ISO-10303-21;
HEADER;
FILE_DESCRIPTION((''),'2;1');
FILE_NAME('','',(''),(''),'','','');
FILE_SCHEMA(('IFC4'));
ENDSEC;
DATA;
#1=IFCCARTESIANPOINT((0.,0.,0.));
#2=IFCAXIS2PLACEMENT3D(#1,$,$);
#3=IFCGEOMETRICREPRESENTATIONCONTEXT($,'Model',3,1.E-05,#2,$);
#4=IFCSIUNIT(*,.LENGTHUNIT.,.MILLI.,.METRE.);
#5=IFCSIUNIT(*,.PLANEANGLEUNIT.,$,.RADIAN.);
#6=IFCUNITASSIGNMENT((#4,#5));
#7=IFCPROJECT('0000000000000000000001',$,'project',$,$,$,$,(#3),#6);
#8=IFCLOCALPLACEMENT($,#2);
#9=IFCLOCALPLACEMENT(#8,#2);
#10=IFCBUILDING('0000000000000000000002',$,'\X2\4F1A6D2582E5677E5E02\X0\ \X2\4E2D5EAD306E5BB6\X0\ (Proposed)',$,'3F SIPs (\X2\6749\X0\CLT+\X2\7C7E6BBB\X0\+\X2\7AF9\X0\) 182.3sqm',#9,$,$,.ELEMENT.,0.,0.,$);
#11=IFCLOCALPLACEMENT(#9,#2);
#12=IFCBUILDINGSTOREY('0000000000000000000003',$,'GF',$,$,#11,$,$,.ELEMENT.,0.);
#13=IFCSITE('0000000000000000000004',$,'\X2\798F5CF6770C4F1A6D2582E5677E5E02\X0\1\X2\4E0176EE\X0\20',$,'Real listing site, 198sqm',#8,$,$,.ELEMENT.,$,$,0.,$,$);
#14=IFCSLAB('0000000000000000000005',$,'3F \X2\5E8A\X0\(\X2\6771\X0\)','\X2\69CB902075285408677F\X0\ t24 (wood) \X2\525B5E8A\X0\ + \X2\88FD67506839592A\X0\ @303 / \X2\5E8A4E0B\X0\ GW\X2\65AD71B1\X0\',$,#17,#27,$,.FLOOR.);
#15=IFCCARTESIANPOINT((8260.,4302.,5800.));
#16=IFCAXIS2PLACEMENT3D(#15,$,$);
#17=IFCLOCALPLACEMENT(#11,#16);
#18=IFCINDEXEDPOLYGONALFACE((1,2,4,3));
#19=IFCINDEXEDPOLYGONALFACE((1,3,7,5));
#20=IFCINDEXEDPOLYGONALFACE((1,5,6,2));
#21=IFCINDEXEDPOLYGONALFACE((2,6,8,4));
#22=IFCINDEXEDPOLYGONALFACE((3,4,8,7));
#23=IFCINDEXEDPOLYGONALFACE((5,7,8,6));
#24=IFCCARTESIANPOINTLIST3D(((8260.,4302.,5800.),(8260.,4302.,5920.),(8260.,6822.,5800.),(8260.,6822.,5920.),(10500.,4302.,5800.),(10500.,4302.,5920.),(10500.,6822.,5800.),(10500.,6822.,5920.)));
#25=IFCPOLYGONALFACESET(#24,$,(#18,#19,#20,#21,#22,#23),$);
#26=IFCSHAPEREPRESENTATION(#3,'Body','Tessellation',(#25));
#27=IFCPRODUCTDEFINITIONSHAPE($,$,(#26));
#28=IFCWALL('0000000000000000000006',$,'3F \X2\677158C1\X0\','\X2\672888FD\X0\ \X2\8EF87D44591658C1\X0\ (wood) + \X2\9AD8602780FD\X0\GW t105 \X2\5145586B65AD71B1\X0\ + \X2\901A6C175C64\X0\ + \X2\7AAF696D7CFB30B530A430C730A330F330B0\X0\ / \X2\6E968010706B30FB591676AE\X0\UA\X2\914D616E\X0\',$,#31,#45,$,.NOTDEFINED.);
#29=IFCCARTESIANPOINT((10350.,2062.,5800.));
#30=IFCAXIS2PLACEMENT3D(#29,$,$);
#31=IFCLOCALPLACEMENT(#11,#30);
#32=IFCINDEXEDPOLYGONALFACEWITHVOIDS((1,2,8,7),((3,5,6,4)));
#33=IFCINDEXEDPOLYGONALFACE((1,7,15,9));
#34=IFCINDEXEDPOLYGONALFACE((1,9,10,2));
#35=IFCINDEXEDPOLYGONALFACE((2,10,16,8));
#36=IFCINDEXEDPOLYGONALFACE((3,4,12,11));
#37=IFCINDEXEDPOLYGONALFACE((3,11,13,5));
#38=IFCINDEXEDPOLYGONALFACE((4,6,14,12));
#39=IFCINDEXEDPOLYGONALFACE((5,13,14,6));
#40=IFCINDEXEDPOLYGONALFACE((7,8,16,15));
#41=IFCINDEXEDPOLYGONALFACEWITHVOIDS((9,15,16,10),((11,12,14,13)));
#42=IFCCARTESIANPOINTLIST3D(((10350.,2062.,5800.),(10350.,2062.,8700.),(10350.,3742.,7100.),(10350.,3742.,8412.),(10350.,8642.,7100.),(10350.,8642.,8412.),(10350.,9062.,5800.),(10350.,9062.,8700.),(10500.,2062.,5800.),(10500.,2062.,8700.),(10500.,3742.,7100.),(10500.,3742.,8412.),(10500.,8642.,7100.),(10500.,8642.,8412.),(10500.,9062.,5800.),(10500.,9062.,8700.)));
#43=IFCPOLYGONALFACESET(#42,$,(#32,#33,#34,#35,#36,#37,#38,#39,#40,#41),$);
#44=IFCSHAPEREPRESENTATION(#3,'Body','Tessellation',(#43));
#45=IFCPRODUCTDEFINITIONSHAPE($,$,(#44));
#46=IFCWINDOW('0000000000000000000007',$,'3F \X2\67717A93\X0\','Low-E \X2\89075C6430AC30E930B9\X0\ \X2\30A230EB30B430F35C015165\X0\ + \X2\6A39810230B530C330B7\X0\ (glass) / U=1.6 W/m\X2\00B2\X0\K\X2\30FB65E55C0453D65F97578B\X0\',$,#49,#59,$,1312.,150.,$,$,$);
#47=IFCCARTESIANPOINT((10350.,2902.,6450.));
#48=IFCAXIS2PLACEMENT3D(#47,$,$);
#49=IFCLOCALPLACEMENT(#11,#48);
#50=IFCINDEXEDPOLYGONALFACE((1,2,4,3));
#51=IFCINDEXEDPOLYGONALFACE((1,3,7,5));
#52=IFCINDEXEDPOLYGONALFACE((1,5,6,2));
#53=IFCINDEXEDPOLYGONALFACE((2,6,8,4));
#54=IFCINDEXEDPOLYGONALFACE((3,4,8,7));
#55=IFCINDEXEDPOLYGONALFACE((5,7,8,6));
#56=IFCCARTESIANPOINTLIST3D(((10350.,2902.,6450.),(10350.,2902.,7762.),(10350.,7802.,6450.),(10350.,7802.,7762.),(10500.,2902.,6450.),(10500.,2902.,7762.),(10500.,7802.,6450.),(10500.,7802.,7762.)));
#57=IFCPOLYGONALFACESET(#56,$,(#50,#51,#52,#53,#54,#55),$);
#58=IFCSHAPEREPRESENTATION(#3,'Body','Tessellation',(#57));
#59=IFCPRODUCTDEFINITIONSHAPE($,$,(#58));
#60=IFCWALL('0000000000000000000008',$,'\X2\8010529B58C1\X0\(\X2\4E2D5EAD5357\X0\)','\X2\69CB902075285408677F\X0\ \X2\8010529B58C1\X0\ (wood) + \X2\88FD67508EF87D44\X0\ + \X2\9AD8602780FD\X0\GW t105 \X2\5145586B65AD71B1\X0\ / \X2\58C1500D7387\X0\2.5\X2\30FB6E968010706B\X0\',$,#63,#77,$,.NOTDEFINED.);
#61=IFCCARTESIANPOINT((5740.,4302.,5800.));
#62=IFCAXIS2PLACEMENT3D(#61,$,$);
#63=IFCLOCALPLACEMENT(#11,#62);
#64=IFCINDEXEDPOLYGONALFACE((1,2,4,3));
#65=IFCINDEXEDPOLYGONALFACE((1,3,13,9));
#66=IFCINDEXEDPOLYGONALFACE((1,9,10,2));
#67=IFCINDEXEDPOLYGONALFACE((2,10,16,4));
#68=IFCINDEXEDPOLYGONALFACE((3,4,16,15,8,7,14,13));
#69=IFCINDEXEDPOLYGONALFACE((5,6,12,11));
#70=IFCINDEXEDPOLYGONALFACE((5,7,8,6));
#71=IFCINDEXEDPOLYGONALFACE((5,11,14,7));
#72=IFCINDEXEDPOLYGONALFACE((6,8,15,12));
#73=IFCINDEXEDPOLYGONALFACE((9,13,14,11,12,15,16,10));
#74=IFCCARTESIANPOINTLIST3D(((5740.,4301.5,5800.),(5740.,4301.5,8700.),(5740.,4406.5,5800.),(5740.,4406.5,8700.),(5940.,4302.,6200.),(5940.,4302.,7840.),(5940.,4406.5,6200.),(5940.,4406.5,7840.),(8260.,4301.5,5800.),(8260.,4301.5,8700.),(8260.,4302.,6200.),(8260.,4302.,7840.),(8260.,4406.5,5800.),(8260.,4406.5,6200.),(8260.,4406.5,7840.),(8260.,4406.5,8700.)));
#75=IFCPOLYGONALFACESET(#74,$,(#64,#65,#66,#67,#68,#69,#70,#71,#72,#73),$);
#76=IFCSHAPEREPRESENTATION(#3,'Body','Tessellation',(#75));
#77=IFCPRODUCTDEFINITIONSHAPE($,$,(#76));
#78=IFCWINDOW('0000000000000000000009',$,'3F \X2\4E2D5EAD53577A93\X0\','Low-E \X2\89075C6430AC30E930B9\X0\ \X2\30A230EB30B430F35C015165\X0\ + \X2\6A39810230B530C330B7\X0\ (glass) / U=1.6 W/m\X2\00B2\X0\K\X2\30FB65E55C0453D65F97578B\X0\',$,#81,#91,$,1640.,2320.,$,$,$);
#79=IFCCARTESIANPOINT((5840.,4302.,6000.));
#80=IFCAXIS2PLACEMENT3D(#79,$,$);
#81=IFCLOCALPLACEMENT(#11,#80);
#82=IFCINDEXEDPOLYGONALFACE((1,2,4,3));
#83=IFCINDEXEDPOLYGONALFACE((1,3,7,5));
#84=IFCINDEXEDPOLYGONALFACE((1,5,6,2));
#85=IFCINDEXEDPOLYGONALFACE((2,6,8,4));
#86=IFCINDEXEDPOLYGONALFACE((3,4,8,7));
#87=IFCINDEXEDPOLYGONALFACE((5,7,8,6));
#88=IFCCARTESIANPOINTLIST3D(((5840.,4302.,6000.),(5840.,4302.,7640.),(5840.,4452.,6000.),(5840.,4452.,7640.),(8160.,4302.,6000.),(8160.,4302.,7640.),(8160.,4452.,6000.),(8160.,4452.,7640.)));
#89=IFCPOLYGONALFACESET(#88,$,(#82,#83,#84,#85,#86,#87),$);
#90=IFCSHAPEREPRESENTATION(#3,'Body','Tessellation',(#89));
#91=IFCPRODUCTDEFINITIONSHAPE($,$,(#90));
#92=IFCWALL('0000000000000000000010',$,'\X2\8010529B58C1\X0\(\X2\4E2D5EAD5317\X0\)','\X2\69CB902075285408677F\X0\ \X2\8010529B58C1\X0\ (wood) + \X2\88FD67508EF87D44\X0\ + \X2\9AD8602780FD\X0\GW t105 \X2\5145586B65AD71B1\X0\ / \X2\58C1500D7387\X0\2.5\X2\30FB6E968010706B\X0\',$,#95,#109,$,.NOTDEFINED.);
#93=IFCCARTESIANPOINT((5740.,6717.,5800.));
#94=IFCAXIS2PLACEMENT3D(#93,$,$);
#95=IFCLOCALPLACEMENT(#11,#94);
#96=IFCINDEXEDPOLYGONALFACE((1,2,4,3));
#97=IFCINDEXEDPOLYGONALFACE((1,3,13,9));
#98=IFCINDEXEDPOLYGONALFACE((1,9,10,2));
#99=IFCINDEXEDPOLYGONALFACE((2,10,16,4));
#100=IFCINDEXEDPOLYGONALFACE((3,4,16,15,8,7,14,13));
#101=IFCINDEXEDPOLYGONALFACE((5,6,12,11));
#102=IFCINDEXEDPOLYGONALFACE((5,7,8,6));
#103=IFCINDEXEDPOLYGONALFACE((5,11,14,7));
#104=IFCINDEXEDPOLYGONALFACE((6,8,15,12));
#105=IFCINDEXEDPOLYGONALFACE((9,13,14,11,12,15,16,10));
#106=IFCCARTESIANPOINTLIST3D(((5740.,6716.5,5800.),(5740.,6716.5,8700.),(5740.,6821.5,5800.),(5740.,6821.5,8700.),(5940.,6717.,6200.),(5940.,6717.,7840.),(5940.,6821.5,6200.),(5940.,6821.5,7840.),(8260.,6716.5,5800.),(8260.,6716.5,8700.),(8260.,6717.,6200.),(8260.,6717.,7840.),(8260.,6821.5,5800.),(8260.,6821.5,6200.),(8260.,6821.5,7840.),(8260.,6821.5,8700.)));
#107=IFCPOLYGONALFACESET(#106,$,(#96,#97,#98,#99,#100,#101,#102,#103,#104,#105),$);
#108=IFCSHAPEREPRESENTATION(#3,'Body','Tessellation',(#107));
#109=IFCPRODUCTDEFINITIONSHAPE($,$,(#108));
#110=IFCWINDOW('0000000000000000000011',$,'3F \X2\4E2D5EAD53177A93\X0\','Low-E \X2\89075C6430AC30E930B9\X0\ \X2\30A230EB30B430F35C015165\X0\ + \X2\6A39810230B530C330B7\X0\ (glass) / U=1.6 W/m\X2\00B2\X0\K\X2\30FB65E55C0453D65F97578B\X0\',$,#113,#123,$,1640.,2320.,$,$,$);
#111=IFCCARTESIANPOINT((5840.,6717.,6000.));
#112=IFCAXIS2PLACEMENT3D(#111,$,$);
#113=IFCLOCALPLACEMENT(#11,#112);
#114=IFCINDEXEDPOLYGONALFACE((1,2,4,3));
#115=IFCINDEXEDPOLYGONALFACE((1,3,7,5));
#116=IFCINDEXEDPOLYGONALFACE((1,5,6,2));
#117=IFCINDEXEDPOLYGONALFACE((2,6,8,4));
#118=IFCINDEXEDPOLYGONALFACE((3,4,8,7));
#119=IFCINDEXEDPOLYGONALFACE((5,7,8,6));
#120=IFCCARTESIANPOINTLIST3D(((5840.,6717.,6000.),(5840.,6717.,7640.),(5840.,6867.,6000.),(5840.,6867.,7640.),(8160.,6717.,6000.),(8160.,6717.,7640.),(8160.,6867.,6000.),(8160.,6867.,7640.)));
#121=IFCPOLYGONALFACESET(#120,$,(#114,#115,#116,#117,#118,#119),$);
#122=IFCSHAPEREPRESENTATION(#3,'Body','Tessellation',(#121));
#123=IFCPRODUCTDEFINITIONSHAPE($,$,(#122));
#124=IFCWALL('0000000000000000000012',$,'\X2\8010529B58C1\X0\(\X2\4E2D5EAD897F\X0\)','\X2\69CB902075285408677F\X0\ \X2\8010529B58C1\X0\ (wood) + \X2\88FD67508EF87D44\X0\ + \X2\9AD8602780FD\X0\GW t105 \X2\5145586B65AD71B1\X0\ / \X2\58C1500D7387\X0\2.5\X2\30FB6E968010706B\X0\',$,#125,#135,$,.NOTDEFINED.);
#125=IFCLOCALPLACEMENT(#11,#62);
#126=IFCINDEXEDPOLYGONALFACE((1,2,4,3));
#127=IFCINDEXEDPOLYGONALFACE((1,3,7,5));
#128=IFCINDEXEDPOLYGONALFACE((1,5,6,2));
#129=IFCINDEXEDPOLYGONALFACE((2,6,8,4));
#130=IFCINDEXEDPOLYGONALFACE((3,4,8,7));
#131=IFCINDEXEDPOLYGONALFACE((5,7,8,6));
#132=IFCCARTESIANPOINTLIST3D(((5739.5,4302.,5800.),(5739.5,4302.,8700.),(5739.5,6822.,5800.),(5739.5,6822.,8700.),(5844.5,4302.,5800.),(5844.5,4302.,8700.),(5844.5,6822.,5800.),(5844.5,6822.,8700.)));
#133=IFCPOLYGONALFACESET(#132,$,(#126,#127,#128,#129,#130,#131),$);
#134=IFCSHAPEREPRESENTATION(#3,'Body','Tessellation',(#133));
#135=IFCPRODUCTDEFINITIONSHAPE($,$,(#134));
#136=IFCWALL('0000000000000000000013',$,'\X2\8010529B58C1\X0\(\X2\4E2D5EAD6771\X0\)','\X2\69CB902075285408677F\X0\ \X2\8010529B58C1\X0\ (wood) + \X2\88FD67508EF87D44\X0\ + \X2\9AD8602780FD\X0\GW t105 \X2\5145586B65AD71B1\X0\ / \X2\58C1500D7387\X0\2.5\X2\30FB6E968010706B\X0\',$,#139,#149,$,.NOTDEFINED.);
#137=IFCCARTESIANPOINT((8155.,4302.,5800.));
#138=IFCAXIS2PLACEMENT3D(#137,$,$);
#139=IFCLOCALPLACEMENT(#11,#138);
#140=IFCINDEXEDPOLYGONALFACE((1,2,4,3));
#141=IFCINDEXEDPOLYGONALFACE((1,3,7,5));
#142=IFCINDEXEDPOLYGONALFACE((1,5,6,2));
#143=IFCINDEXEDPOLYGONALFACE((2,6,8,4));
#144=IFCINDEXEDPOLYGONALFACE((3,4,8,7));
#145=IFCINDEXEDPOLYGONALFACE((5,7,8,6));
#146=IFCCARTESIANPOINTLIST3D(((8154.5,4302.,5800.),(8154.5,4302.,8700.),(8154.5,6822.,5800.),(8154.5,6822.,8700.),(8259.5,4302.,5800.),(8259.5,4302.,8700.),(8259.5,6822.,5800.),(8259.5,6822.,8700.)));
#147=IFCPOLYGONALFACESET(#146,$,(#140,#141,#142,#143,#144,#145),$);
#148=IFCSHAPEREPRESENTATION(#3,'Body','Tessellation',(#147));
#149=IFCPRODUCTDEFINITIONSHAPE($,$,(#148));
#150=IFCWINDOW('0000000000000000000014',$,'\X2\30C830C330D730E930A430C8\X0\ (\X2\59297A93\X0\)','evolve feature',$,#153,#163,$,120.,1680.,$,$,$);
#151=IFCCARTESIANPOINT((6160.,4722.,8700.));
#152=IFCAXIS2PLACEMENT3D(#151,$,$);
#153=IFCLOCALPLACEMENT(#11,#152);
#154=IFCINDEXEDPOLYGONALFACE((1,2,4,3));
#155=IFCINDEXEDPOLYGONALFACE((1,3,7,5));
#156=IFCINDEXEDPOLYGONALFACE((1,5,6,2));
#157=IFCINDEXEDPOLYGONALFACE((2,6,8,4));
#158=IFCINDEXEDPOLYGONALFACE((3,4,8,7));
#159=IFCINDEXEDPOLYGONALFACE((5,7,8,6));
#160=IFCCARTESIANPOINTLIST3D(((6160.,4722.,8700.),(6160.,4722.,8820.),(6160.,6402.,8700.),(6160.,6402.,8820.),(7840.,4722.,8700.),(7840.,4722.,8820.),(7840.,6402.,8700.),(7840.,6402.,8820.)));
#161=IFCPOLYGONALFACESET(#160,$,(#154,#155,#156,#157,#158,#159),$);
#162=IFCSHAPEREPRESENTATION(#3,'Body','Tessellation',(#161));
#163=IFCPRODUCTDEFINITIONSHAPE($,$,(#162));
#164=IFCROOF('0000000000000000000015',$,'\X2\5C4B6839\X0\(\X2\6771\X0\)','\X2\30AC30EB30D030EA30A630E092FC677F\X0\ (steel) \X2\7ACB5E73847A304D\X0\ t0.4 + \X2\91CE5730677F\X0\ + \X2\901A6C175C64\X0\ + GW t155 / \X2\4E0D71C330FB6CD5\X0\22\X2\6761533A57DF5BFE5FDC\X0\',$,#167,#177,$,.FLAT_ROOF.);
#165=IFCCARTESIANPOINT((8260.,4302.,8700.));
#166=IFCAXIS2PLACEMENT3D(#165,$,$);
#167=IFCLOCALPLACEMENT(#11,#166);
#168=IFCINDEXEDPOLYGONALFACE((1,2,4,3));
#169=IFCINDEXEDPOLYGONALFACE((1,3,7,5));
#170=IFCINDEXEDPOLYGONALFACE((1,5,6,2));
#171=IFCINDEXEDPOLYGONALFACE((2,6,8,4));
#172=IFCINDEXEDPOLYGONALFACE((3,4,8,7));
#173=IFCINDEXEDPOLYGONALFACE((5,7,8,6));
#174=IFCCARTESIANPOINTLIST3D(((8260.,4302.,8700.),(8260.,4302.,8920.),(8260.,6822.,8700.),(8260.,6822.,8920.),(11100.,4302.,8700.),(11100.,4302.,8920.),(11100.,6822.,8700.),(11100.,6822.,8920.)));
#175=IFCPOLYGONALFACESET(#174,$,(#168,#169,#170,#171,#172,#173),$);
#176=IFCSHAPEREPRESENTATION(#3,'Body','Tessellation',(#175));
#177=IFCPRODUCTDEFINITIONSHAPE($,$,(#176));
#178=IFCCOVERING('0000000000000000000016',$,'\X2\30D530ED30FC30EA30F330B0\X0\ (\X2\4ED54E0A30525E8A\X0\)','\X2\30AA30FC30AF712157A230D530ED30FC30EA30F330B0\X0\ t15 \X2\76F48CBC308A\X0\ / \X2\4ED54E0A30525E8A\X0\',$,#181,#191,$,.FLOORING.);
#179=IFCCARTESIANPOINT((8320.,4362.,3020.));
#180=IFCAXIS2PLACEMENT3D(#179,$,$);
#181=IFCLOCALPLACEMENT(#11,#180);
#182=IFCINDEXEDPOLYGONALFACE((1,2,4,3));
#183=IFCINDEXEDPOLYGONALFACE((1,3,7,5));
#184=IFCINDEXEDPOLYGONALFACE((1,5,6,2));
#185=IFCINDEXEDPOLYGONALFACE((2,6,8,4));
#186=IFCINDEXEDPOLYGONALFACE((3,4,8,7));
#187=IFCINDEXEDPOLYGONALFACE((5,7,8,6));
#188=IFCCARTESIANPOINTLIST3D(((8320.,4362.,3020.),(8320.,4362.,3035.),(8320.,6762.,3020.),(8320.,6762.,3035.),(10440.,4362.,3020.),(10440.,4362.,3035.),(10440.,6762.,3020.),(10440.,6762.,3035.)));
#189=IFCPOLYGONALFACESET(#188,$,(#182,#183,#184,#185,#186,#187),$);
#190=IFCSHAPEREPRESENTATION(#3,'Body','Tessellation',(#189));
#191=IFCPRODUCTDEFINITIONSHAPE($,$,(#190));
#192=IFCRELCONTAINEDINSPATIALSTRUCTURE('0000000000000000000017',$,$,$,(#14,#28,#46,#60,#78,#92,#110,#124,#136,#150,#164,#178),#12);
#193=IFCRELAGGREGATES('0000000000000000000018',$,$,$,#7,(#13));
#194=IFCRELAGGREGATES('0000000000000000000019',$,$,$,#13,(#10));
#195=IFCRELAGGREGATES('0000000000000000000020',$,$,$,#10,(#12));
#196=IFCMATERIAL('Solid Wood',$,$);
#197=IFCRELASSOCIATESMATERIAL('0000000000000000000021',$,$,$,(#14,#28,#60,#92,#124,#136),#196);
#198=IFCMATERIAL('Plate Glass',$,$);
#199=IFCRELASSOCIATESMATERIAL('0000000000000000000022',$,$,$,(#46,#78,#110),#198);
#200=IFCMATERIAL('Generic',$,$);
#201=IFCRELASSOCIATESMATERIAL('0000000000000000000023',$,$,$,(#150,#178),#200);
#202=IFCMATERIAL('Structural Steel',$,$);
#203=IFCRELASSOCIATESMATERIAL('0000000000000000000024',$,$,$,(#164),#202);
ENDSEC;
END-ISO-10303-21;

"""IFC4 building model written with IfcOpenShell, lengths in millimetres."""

from ifc_helpers import new_model, si_unit, frame, frame_2d, origin, place, context, project, spatial, rectangle, extrude, material, element, fill, save


model = new_model("IFC4")

# Units and contexts
model_context = context("Model", 3, precision=1e-05, world=origin())
ifc_project = project(units=[si_unit("LENGTHUNIT", "METRE", prefix="MILLI"), si_unit("PLANEANGLEUNIT", "RADIAN")], contexts=[model_context])

# Site, building, storey
site_placement = place(None, origin())
site = spatial("IfcSite", under=ifc_project, at=site_placement, Name="福島県会津若松市1丁目20", ObjectType="Real listing site, 198sqm", CompositionType="ELEMENT", RefElevation=0.0)
building_placement = place(site_placement, origin())
building = spatial("IfcBuilding", under=site, at=building_placement, Name="会津若松市 中庭の家 (Proposed)", ObjectType="3F SIPs (杉CLT+籾殻+竹) 182.3sqm", CompositionType="ELEMENT", ElevationOfRefHeight=0.0, ElevationOfTerrain=0.0)
storey_placement = place(building_placement, origin())
storey = spatial("IfcBuildingStorey", under=building, at=storey_placement, Name="GF", CompositionType="ELEMENT", Elevation=0.0)

# Slab
ifc_material_1 = material(Name="Solid Wood")
slab_placement = place(storey_placement, frame((8260.0, 4302.0, 5800.0)))
element("IfcSlab", 1, at=slab_placement, inside=storey, material=ifc_material_1, Name="3F 床(東)", Description="構造用合板 t24 (wood) 剛床 + 製材根太 @303 / 床下 GW断熱", PredefinedType="FLOOR", context=model_context, shape_type="SweptSolid", body=[
    extrude(rectangle(XDim=2240.0, YDim=2520.0, at=frame_2d((1120.0, 1260.0))), frame((8260.0, 4302.0, 5800.0)), (0.0, 0.0, 1.0), 120.0),
])

# Walls, openings, windows
wall_1_placement = place(storey_placement, frame((10350.0, 2062.0, 5800.0)))
wall_1 = element("IfcWall", 2, at=wall_1_placement, inside=storey, material=ifc_material_1, Name="3F 東壁", Description="木製 軸組外壁 (wood) + 高性能GW t105 充填断熱 + 通気層 + 窯業系サイディング / 準耐火・外皮UA配慮", PredefinedType="NOTDEFINED", context=model_context, shape_type="SweptSolid", body=[
    extrude(rectangle(XDim=150.0, YDim=7000.0, at=frame_2d((75.0, 3500.0))), frame((10350.0, 2062.0, 5800.0)), (0.0, 0.0, 1.0), 2900.0),
])
opening_1_placement = place(storey_placement, frame((10350.0, 2902.0, 6450.0)))
opening_1 = element("IfcOpeningElement", 3, at=opening_1_placement, cuts=wall_1, PredefinedType="NOTDEFINED", context=model_context, shape_type="SweptSolid", body=[
    extrude(rectangle(XDim=150.0, YDim=4900.0, at=frame_2d((75.0, 2450.0))), frame((10350.0, 2902.0, 6450.0)), (0.0, 0.0, 1.0), 1312.0),
])
ifc_material_2 = material(Name="Plate Glass")
window_1_placement = place(storey_placement, frame((10350.0, 2902.0, 6450.0)))
window_1 = element("IfcWindow", 4, at=window_1_placement, inside=storey, material=ifc_material_2, Name="3F 東窓", Description="Low-E 複層ガラス アルゴン封入 + 樹脂サッシ (glass) / U=1.6 W/m²K・日射取得型", OverallHeight=1312.0, OverallWidth=150.0, context=model_context, shape_type="SweptSolid", body=[
    extrude(rectangle(XDim=150.0, YDim=4900.0, at=frame_2d((75.0, 2450.0))), frame((10350.0, 2902.0, 6450.0)), (0.0, 0.0, 1.0), 1312.0),
])
fill(opening_1, window_1)
wall_2_placement = place(storey_placement, frame((5740.0, 4302.0, 5800.0)))
wall_2 = element("IfcWall", 5, at=wall_2_placement, inside=storey, material=ifc_material_1, Name="耐力壁(中庭南)", Description="構造用合板 耐力壁 (wood) + 製材軸組 + 高性能GW t105 充填断熱 / 壁倍率2.5・準耐火", PredefinedType="NOTDEFINED", context=model_context, shape_type="SweptSolid", body=[
    extrude(rectangle(XDim=2520.0, YDim=105.0, at=frame_2d((1260.0, 52.0))), frame((5740.0, 4302.0, 5800.0)), (0.0, 0.0, 1.0), 2900.0),
])
opening_2_placement = place(storey_placement, frame((5840.0, 4302.0, 6000.0)))
opening_2 = element("IfcOpeningElement", 6, at=opening_2_placement, cuts=wall_2, PredefinedType="NOTDEFINED", context=model_context, shape_type="SweptSolid", body=[
    extrude(rectangle(XDim=2320.0, YDim=150.0, at=frame_2d((1160.0, 75.0))), frame((5840.0, 4302.0, 6000.0)), (0.0, 0.0, 1.0), 1640.0),
])
window_2_placement = place(storey_placement, frame((5840.0, 4302.0, 6000.0)))
window_2 = element("IfcWindow", 7, at=window_2_placement, inside=storey, material=ifc_material_2, Name="3F 中庭南窓", Description="Low-E 複層ガラス アルゴン封入 + 樹脂サッシ (glass) / U=1.6 W/m²K・日射取得型", OverallHeight=1640.0, OverallWidth=2320.0, context=model_context, shape_type="SweptSolid", body=[
    extrude(rectangle(XDim=2320.0, YDim=150.0, at=frame_2d((1160.0, 75.0))), frame((5840.0, 4302.0, 6000.0)), (0.0, 0.0, 1.0), 1640.0),
])
fill(opening_2, window_2)
wall_3_placement = place(storey_placement, frame((5740.0, 6717.0, 5800.0)))
wall_3 = element("IfcWall", 8, at=wall_3_placement, inside=storey, material=ifc_material_1, Name="耐力壁(中庭北)", Description="構造用合板 耐力壁 (wood) + 製材軸組 + 高性能GW t105 充填断熱 / 壁倍率2.5・準耐火", PredefinedType="NOTDEFINED", context=model_context, shape_type="SweptSolid", body=[
    extrude(rectangle(XDim=2520.0, YDim=105.0, at=frame_2d((1260.0, 52.0))), frame((5740.0, 6717.0, 5800.0)), (0.0, 0.0, 1.0), 2900.0),
])
opening_3_placement = place(storey_placement, frame((5840.0, 6717.0, 6000.0)))
opening_3 = element("IfcOpeningElement", 9, at=opening_3_placement, cuts=wall_3, PredefinedType="NOTDEFINED", context=model_context, shape_type="SweptSolid", body=[
    extrude(rectangle(XDim=2320.0, YDim=150.0, at=frame_2d((1160.0, 75.0))), frame((5840.0, 6717.0, 6000.0)), (0.0, 0.0, 1.0), 1640.0),
])
window_3_placement = place(storey_placement, frame((5840.0, 6717.0, 6000.0)))
window_3 = element("IfcWindow", 10, at=window_3_placement, inside=storey, material=ifc_material_2, Name="3F 中庭北窓", Description="Low-E 複層ガラス アルゴン封入 + 樹脂サッシ (glass) / U=1.6 W/m²K・日射取得型", OverallHeight=1640.0, OverallWidth=2320.0, context=model_context, shape_type="SweptSolid", body=[
    extrude(rectangle(XDim=2320.0, YDim=150.0, at=frame_2d((1160.0, 75.0))), frame((5840.0, 6717.0, 6000.0)), (0.0, 0.0, 1.0), 1640.0),
])
fill(opening_3, window_3)

# Walls
wall_4_placement = place(storey_placement, frame((5740.0, 4302.0, 5800.0)))
element("IfcWall", 11, at=wall_4_placement, inside=storey, material=ifc_material_1, Name="耐力壁(中庭西)", Description="構造用合板 耐力壁 (wood) + 製材軸組 + 高性能GW t105 充填断熱 / 壁倍率2.5・準耐火", PredefinedType="NOTDEFINED", context=model_context, shape_type="SweptSolid", body=[
    extrude(rectangle(XDim=105.0, YDim=2520.0, at=frame_2d((52.0, 1260.0))), frame((5740.0, 4302.0, 5800.0)), (0.0, 0.0, 1.0), 2900.0),
])
wall_5_placement = place(storey_placement, frame((8155.0, 4302.0, 5800.0)))
element("IfcWall", 12, at=wall_5_placement, inside=storey, material=ifc_material_1, Name="耐力壁(中庭東)", Description="構造用合板 耐力壁 (wood) + 製材軸組 + 高性能GW t105 充填断熱 / 壁倍率2.5・準耐火", PredefinedType="NOTDEFINED", context=model_context, shape_type="SweptSolid", body=[
    extrude(rectangle(XDim=105.0, YDim=2520.0, at=frame_2d((52.0, 1260.0))), frame((8155.0, 4302.0, 5800.0)), (0.0, 0.0, 1.0), 2900.0),
])

# Window
ifc_material_3 = material(Name="Generic")
window_4_placement = place(storey_placement, frame((6160.0, 4722.0, 8700.0)))
element("IfcWindow", 13, at=window_4_placement, inside=storey, material=ifc_material_3, Name="トップライト (天窓)", Description="evolve feature", OverallHeight=120.0, OverallWidth=1680.0, context=model_context, shape_type="SweptSolid", body=[
    extrude(rectangle(XDim=1680.0, YDim=1680.0, at=frame_2d((840.0, 840.0))), frame((6160.0, 4722.0, 8700.0)), (0.0, 0.0, 1.0), 120.0),
])

# Roof
ifc_material_4 = material(Name="Structural Steel")
for number, where, name in (
    (14, (8260.0, 4302.0, 8700.0), "屋根(東)"),
):
    element("IfcRoof", number, at=place(storey_placement, frame(where)), inside=storey, material=ifc_material_4, Name=name, Description="ガルバリウム鋼板 (steel) 立平葺き t0.4 + 野地板 + 通気層 + GW t155 / 不燃・法22条区域対応", PredefinedType="FLAT_ROOF", context=model_context, shape_type="SweptSolid", body=[
        extrude(rectangle(XDim=2840.0, YDim=2520.0, at=frame_2d((1420.0, 1260.0))), frame((8260.0, 4302.0, 8700.0)), (0.0, 0.0, 1.0), 220.0),
    ])

# Covering
covering_1_placement = place(storey_placement, frame((8320.0, 4362.0, 3020.0)))
element("IfcCovering", 15, at=covering_1_placement, inside=storey, material=ifc_material_3, Name="フローリング (仕上げ床)", Description="オーク無垢フローリング t15 直貼り / 仕上げ床", PredefinedType="FLOORING", context=model_context, shape_type="SweptSolid", body=[
    extrude(rectangle(XDim=2120.0, YDim=2400.0, at=frame_2d((1060.0, 1200.0))), frame((8320.0, 4362.0, 3020.0)), (0.0, 0.0, 1.0), 15.0),
])

save(model, "model.ifc")
